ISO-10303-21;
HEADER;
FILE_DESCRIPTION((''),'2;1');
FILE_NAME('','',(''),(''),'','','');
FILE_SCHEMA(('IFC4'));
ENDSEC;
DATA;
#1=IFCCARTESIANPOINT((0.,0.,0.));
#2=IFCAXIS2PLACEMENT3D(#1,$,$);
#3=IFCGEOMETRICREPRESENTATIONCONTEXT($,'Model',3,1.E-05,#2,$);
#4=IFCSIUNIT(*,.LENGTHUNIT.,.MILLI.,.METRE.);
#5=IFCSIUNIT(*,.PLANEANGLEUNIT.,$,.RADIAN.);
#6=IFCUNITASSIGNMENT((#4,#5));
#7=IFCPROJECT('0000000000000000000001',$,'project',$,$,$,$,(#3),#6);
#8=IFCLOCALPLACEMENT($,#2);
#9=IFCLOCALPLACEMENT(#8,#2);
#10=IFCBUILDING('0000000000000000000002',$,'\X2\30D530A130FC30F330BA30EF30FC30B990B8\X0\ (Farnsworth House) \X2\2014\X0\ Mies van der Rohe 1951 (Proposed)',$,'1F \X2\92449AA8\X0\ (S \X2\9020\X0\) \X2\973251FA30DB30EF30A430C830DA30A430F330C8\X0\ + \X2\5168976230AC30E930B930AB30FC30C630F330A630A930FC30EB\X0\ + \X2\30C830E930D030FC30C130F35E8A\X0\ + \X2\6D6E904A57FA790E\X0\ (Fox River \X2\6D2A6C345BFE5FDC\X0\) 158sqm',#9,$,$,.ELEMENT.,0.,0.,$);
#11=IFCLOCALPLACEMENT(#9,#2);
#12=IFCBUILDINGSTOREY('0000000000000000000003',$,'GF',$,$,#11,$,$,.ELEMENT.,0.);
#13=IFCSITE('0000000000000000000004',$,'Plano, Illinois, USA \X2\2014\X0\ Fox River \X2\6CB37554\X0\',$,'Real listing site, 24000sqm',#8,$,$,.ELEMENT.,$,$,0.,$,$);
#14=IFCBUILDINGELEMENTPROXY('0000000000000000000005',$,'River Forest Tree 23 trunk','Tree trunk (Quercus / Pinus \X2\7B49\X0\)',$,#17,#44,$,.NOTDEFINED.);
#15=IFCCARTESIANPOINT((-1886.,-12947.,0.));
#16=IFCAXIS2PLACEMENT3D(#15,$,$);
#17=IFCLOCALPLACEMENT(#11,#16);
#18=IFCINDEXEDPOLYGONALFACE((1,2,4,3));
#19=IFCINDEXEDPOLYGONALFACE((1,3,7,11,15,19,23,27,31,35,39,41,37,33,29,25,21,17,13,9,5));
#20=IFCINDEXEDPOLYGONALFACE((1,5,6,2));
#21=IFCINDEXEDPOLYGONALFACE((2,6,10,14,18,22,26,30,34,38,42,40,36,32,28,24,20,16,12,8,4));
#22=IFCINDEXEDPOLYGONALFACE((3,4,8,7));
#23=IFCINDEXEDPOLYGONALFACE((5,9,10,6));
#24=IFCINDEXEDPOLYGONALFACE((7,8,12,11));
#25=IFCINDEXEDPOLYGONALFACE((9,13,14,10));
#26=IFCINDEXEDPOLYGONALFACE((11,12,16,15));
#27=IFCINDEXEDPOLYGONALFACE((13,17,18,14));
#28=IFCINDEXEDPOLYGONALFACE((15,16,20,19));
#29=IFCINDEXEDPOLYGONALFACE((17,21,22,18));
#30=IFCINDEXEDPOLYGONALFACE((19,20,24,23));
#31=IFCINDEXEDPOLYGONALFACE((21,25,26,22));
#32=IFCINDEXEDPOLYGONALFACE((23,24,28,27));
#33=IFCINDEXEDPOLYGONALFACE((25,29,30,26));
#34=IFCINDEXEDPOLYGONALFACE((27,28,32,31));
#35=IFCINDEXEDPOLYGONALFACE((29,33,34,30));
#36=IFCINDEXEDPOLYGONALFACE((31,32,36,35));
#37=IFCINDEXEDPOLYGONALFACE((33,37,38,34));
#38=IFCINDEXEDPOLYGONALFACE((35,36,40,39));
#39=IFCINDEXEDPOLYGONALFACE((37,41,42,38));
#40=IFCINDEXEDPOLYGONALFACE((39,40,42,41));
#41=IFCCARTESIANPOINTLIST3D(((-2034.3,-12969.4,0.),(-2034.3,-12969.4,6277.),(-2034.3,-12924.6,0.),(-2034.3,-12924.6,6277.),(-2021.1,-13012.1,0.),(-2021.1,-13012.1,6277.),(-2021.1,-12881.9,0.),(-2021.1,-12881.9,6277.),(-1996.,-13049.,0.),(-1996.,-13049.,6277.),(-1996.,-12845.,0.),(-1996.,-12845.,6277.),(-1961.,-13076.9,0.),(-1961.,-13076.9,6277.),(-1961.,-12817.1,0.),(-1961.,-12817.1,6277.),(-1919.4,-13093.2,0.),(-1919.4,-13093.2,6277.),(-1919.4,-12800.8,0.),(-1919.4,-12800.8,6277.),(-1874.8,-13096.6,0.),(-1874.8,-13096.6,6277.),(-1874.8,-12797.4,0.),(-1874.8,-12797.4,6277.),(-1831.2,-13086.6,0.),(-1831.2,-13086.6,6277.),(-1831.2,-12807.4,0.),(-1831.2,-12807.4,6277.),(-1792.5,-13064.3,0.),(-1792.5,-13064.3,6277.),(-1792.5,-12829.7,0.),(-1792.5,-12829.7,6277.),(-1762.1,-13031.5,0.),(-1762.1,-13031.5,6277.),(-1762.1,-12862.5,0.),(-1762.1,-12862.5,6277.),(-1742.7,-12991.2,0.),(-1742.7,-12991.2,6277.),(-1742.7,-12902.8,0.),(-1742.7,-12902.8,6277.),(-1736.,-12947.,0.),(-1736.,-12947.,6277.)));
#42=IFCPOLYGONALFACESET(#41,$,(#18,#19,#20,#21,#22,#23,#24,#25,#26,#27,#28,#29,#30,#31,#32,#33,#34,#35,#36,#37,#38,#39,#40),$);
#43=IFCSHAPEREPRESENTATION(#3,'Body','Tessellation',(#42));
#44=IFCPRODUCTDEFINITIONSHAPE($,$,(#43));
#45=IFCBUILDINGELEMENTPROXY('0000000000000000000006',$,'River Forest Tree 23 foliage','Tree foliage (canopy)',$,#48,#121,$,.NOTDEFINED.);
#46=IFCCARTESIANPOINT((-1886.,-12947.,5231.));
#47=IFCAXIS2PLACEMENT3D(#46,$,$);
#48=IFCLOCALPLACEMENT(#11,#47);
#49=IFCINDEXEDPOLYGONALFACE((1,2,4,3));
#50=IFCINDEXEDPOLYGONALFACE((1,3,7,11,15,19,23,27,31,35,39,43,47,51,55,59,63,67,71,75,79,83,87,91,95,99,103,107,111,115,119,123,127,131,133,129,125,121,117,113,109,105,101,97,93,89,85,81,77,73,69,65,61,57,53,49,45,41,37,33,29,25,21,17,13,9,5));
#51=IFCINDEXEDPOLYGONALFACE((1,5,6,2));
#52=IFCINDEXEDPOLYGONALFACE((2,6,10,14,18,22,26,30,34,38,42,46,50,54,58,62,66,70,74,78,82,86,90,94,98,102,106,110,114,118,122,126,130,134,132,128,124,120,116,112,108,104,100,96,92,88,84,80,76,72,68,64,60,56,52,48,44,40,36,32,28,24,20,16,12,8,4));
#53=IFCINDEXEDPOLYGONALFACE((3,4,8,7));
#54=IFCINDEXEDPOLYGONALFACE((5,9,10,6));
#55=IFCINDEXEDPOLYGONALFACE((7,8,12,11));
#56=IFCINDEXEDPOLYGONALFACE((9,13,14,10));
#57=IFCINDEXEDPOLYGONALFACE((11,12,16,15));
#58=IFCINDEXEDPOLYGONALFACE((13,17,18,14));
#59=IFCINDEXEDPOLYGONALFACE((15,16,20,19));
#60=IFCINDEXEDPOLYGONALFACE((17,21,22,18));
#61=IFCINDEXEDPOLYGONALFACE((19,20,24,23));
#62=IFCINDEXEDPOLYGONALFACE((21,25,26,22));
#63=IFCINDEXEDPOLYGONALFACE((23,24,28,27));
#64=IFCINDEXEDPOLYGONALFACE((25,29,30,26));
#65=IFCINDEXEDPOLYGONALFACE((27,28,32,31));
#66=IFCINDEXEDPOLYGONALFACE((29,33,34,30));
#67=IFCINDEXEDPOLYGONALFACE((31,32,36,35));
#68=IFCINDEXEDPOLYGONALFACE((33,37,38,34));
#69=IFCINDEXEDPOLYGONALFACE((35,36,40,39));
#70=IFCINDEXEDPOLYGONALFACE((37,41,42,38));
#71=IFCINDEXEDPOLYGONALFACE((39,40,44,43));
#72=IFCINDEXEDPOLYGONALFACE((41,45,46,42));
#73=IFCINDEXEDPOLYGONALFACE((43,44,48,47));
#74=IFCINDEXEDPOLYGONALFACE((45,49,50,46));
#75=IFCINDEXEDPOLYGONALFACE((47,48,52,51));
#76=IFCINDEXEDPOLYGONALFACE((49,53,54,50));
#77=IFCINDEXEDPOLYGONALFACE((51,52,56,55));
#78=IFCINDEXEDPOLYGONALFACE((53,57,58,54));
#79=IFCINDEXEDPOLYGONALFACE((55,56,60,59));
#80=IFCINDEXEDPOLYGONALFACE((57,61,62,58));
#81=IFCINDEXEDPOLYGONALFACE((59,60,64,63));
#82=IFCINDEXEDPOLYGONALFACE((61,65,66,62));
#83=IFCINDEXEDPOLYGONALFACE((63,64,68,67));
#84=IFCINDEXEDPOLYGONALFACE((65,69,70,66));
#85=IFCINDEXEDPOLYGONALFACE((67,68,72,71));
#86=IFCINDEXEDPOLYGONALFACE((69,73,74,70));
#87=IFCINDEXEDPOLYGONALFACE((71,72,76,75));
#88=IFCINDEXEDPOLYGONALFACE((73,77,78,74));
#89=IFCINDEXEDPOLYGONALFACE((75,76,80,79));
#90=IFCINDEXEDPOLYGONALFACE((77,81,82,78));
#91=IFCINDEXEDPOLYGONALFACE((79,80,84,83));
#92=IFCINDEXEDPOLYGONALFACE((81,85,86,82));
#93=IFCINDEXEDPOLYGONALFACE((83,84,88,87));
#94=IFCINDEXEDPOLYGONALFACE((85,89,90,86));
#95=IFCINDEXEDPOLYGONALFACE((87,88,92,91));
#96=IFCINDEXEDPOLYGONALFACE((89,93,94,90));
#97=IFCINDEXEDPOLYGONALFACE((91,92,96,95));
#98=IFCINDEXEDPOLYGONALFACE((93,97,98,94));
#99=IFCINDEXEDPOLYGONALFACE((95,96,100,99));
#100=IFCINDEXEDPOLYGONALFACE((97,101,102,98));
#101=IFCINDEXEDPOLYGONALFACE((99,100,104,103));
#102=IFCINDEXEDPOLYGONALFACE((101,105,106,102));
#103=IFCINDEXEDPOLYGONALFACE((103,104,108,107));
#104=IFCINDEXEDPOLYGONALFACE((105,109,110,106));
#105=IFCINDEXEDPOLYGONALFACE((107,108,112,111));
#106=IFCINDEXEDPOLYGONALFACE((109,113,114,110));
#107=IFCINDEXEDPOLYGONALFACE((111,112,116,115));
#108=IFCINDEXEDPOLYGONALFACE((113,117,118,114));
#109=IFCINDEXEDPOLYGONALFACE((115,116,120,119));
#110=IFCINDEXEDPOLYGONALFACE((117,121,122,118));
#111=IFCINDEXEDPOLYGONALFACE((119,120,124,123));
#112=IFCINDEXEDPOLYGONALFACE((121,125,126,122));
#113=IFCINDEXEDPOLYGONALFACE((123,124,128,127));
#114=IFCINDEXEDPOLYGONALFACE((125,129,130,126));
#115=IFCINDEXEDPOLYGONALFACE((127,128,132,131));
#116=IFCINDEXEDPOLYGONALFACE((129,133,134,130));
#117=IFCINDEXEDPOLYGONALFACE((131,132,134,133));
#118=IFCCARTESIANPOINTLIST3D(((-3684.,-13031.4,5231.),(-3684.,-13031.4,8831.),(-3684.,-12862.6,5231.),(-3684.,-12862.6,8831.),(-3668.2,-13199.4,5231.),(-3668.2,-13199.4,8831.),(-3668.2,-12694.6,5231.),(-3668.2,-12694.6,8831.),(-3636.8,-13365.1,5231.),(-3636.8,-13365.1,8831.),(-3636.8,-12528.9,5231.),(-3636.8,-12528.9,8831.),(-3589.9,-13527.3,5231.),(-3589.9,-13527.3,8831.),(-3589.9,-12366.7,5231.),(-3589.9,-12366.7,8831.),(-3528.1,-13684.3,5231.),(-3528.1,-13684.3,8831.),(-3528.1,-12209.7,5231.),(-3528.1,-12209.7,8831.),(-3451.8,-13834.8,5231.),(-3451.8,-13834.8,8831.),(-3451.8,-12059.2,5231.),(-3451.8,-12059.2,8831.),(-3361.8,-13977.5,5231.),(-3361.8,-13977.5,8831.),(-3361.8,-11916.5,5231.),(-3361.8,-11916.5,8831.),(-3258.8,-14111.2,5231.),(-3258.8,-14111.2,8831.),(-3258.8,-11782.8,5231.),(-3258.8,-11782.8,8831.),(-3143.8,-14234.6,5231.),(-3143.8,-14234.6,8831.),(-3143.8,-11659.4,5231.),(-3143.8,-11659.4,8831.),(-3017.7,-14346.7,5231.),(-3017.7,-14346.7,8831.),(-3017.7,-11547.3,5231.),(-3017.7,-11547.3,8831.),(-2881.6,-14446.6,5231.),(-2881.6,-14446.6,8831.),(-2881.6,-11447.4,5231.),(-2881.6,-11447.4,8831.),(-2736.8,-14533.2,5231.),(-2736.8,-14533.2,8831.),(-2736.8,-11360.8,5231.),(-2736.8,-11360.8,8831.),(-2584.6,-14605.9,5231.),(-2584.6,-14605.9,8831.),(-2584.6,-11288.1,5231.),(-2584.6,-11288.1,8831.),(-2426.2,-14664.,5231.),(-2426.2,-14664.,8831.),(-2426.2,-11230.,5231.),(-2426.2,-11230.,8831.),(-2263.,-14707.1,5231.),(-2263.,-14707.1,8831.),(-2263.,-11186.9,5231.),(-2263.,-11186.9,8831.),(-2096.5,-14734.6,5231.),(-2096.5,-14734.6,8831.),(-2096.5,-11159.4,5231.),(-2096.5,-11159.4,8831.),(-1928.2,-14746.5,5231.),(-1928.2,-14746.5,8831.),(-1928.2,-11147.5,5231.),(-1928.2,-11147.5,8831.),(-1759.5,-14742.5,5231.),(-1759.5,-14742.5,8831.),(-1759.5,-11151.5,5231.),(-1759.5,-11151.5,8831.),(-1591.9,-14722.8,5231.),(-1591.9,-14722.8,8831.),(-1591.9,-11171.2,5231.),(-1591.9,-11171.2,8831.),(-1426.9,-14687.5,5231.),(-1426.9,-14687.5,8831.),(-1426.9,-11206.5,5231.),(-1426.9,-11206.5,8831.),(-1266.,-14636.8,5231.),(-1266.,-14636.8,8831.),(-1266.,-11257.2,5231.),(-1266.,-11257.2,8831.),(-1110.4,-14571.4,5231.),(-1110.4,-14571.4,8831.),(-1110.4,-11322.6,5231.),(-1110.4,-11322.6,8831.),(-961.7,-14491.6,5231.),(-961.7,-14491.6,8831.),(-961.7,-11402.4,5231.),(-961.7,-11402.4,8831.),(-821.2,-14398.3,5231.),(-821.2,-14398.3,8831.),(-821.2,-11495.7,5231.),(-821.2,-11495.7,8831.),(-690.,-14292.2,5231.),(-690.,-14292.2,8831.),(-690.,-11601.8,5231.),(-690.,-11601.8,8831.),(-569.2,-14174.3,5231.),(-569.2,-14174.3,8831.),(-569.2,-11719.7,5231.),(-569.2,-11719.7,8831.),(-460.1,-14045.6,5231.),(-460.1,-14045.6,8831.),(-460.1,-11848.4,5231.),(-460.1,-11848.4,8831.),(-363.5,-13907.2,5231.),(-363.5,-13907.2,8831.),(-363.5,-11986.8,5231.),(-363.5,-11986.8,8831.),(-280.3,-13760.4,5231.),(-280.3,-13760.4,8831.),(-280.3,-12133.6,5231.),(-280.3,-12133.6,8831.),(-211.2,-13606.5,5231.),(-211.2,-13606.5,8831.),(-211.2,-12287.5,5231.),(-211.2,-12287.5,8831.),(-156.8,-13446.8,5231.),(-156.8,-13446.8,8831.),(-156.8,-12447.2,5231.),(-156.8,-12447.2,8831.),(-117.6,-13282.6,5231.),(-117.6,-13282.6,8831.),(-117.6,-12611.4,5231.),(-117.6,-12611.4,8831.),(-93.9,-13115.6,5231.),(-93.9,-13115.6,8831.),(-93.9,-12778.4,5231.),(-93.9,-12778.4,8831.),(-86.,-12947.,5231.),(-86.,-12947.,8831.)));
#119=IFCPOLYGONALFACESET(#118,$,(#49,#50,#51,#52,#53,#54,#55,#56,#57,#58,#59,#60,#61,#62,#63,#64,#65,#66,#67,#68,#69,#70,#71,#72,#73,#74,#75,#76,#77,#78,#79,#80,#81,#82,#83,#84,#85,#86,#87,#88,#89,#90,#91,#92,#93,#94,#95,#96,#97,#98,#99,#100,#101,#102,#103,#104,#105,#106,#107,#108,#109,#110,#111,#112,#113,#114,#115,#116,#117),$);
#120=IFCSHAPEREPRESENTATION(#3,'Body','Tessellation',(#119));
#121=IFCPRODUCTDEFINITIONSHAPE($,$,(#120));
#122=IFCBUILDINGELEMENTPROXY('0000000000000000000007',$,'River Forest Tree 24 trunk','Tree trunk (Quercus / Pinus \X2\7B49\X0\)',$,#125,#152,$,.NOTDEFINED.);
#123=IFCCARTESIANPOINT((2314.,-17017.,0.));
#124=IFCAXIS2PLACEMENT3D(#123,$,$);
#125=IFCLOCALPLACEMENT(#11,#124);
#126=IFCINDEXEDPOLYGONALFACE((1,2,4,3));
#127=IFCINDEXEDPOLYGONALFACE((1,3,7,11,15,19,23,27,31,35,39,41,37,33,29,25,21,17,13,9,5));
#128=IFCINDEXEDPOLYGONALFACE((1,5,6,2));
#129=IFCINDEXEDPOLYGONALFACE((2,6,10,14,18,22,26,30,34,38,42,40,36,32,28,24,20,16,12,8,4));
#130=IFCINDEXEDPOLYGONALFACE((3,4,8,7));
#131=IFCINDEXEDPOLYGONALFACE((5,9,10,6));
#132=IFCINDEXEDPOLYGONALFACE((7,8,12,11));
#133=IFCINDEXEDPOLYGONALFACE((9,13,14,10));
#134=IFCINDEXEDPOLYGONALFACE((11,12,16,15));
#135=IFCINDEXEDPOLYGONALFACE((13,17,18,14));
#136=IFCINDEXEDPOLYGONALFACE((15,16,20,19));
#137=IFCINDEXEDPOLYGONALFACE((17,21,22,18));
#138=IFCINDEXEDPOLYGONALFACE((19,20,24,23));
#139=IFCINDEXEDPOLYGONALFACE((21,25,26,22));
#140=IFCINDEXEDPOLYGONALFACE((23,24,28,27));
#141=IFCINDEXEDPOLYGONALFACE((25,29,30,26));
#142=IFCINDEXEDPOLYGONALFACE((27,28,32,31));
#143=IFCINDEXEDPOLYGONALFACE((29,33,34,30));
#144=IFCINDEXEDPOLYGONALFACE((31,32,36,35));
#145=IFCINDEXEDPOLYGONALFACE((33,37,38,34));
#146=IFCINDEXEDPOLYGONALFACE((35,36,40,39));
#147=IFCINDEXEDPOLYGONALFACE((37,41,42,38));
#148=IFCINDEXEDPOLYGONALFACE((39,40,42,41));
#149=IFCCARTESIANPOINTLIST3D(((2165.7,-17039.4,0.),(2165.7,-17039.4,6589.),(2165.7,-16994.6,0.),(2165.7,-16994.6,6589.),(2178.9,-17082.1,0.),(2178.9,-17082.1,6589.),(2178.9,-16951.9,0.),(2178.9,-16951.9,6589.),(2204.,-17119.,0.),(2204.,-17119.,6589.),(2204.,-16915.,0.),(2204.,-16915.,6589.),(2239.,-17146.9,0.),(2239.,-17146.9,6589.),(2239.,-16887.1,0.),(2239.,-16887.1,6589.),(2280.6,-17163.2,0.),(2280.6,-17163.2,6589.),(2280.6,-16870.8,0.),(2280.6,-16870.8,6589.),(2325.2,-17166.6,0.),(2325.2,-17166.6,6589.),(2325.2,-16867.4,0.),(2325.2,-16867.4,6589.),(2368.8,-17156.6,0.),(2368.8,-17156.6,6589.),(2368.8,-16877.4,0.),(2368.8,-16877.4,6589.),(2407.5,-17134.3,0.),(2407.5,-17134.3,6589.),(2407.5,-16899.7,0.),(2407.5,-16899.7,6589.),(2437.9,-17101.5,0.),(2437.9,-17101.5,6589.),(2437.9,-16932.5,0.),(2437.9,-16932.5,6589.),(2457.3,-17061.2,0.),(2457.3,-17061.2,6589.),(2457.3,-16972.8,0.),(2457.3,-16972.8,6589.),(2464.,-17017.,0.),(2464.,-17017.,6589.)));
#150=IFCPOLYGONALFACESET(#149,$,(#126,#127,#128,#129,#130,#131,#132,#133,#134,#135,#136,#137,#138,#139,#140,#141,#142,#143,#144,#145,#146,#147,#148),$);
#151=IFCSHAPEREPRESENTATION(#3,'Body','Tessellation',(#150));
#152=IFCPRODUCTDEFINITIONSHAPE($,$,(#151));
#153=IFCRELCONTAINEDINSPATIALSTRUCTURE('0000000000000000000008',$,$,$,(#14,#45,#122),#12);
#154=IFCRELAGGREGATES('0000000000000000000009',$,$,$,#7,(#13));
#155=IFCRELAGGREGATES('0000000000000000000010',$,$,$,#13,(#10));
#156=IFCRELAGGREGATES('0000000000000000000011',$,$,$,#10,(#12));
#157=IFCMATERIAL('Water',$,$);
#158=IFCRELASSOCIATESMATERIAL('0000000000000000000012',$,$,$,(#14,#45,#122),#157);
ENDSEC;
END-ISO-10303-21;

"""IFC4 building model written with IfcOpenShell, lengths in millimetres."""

from ifc_helpers import new_model, si_unit, frame, origin, origin_2d, place, context, project, spatial, circle, extrude, material, element, save


model = new_model("IFC4")

# Units and contexts
model_context = context("Model", 3, precision=1e-05, world=origin())
ifc_project = project(units=[si_unit("LENGTHUNIT", "METRE", prefix="MILLI"), si_unit("PLANEANGLEUNIT", "RADIAN")], contexts=[model_context])

# Site, building, storey
site_placement = place(None, origin())
site = spatial("IfcSite", under=ifc_project, at=site_placement, Name="Plano, Illinois, USA — Fox River 河畔", ObjectType="Real listing site, 24000sqm", CompositionType="ELEMENT", RefElevation=0.0)
building_placement = place(site_placement, origin())
building = spatial("IfcBuilding", under=site, at=building_placement, Name="ファーンズワース邸 (Farnsworth House) — Mies van der Rohe 1951 (Proposed)", ObjectType="1F 鉄骨 (S 造) 露出ホワイトペイント + 全面ガラスカーテンウォール + トラバーチン床 + 浮遊基礎 (Fox River 洪水対応) 158sqm", CompositionType="ELEMENT", ElevationOfRefHeight=0.0, ElevationOfTerrain=0.0)
storey_placement = place(building_placement, origin())
storey = spatial("IfcBuildingStorey", under=building, at=storey_placement, Name="GF", CompositionType="ELEMENT", Elevation=0.0)

# Building element proxies
ifc_material_1 = material(Name="Water")
proxy_1_placement = place(storey_placement, frame((-1886.0, -12947.0, 0.0)))
element("IfcBuildingElementProxy", 1, at=proxy_1_placement, inside=storey, material=ifc_material_1, Name="River Forest Tree 23 trunk", Description="Tree trunk (Quercus / Pinus 等)", PredefinedType="NOTDEFINED", context=model_context, shape_type="SweptSolid", body=[
    extrude(circle(Radius=150.0, at=origin_2d()), frame((-1886.0, -12947.0, 0.0)), (0.0, 0.0, 1.0), 6277.0),
])
proxy_2_placement = place(storey_placement, frame((-1886.0, -12947.0, 5231.0)))
element("IfcBuildingElementProxy", 2, at=proxy_2_placement, inside=storey, material=ifc_material_1, Name="River Forest Tree 23 foliage", Description="Tree foliage (canopy)", PredefinedType="NOTDEFINED", context=model_context, shape_type="SweptSolid", body=[
    extrude(circle(Radius=1800.0, at=origin_2d()), frame((-1886.0, -12947.0, 5231.0)), (0.0, 0.0, 1.0), 3600.0),
])
proxy_3_placement = place(storey_placement, frame((2314.0, -17017.0, 0.0)))
element("IfcBuildingElementProxy", 3, at=proxy_3_placement, inside=storey, material=ifc_material_1, Name="River Forest Tree 24 trunk", Description="Tree trunk (Quercus / Pinus 等)", PredefinedType="NOTDEFINED", context=model_context, shape_type="SweptSolid", body=[
    extrude(circle(Radius=150.0, at=origin_2d()), frame((2314.0, -17017.0, 0.0)), (0.0, 0.0, 1.0), 6589.0),
])

save(model, "model.ifc")
